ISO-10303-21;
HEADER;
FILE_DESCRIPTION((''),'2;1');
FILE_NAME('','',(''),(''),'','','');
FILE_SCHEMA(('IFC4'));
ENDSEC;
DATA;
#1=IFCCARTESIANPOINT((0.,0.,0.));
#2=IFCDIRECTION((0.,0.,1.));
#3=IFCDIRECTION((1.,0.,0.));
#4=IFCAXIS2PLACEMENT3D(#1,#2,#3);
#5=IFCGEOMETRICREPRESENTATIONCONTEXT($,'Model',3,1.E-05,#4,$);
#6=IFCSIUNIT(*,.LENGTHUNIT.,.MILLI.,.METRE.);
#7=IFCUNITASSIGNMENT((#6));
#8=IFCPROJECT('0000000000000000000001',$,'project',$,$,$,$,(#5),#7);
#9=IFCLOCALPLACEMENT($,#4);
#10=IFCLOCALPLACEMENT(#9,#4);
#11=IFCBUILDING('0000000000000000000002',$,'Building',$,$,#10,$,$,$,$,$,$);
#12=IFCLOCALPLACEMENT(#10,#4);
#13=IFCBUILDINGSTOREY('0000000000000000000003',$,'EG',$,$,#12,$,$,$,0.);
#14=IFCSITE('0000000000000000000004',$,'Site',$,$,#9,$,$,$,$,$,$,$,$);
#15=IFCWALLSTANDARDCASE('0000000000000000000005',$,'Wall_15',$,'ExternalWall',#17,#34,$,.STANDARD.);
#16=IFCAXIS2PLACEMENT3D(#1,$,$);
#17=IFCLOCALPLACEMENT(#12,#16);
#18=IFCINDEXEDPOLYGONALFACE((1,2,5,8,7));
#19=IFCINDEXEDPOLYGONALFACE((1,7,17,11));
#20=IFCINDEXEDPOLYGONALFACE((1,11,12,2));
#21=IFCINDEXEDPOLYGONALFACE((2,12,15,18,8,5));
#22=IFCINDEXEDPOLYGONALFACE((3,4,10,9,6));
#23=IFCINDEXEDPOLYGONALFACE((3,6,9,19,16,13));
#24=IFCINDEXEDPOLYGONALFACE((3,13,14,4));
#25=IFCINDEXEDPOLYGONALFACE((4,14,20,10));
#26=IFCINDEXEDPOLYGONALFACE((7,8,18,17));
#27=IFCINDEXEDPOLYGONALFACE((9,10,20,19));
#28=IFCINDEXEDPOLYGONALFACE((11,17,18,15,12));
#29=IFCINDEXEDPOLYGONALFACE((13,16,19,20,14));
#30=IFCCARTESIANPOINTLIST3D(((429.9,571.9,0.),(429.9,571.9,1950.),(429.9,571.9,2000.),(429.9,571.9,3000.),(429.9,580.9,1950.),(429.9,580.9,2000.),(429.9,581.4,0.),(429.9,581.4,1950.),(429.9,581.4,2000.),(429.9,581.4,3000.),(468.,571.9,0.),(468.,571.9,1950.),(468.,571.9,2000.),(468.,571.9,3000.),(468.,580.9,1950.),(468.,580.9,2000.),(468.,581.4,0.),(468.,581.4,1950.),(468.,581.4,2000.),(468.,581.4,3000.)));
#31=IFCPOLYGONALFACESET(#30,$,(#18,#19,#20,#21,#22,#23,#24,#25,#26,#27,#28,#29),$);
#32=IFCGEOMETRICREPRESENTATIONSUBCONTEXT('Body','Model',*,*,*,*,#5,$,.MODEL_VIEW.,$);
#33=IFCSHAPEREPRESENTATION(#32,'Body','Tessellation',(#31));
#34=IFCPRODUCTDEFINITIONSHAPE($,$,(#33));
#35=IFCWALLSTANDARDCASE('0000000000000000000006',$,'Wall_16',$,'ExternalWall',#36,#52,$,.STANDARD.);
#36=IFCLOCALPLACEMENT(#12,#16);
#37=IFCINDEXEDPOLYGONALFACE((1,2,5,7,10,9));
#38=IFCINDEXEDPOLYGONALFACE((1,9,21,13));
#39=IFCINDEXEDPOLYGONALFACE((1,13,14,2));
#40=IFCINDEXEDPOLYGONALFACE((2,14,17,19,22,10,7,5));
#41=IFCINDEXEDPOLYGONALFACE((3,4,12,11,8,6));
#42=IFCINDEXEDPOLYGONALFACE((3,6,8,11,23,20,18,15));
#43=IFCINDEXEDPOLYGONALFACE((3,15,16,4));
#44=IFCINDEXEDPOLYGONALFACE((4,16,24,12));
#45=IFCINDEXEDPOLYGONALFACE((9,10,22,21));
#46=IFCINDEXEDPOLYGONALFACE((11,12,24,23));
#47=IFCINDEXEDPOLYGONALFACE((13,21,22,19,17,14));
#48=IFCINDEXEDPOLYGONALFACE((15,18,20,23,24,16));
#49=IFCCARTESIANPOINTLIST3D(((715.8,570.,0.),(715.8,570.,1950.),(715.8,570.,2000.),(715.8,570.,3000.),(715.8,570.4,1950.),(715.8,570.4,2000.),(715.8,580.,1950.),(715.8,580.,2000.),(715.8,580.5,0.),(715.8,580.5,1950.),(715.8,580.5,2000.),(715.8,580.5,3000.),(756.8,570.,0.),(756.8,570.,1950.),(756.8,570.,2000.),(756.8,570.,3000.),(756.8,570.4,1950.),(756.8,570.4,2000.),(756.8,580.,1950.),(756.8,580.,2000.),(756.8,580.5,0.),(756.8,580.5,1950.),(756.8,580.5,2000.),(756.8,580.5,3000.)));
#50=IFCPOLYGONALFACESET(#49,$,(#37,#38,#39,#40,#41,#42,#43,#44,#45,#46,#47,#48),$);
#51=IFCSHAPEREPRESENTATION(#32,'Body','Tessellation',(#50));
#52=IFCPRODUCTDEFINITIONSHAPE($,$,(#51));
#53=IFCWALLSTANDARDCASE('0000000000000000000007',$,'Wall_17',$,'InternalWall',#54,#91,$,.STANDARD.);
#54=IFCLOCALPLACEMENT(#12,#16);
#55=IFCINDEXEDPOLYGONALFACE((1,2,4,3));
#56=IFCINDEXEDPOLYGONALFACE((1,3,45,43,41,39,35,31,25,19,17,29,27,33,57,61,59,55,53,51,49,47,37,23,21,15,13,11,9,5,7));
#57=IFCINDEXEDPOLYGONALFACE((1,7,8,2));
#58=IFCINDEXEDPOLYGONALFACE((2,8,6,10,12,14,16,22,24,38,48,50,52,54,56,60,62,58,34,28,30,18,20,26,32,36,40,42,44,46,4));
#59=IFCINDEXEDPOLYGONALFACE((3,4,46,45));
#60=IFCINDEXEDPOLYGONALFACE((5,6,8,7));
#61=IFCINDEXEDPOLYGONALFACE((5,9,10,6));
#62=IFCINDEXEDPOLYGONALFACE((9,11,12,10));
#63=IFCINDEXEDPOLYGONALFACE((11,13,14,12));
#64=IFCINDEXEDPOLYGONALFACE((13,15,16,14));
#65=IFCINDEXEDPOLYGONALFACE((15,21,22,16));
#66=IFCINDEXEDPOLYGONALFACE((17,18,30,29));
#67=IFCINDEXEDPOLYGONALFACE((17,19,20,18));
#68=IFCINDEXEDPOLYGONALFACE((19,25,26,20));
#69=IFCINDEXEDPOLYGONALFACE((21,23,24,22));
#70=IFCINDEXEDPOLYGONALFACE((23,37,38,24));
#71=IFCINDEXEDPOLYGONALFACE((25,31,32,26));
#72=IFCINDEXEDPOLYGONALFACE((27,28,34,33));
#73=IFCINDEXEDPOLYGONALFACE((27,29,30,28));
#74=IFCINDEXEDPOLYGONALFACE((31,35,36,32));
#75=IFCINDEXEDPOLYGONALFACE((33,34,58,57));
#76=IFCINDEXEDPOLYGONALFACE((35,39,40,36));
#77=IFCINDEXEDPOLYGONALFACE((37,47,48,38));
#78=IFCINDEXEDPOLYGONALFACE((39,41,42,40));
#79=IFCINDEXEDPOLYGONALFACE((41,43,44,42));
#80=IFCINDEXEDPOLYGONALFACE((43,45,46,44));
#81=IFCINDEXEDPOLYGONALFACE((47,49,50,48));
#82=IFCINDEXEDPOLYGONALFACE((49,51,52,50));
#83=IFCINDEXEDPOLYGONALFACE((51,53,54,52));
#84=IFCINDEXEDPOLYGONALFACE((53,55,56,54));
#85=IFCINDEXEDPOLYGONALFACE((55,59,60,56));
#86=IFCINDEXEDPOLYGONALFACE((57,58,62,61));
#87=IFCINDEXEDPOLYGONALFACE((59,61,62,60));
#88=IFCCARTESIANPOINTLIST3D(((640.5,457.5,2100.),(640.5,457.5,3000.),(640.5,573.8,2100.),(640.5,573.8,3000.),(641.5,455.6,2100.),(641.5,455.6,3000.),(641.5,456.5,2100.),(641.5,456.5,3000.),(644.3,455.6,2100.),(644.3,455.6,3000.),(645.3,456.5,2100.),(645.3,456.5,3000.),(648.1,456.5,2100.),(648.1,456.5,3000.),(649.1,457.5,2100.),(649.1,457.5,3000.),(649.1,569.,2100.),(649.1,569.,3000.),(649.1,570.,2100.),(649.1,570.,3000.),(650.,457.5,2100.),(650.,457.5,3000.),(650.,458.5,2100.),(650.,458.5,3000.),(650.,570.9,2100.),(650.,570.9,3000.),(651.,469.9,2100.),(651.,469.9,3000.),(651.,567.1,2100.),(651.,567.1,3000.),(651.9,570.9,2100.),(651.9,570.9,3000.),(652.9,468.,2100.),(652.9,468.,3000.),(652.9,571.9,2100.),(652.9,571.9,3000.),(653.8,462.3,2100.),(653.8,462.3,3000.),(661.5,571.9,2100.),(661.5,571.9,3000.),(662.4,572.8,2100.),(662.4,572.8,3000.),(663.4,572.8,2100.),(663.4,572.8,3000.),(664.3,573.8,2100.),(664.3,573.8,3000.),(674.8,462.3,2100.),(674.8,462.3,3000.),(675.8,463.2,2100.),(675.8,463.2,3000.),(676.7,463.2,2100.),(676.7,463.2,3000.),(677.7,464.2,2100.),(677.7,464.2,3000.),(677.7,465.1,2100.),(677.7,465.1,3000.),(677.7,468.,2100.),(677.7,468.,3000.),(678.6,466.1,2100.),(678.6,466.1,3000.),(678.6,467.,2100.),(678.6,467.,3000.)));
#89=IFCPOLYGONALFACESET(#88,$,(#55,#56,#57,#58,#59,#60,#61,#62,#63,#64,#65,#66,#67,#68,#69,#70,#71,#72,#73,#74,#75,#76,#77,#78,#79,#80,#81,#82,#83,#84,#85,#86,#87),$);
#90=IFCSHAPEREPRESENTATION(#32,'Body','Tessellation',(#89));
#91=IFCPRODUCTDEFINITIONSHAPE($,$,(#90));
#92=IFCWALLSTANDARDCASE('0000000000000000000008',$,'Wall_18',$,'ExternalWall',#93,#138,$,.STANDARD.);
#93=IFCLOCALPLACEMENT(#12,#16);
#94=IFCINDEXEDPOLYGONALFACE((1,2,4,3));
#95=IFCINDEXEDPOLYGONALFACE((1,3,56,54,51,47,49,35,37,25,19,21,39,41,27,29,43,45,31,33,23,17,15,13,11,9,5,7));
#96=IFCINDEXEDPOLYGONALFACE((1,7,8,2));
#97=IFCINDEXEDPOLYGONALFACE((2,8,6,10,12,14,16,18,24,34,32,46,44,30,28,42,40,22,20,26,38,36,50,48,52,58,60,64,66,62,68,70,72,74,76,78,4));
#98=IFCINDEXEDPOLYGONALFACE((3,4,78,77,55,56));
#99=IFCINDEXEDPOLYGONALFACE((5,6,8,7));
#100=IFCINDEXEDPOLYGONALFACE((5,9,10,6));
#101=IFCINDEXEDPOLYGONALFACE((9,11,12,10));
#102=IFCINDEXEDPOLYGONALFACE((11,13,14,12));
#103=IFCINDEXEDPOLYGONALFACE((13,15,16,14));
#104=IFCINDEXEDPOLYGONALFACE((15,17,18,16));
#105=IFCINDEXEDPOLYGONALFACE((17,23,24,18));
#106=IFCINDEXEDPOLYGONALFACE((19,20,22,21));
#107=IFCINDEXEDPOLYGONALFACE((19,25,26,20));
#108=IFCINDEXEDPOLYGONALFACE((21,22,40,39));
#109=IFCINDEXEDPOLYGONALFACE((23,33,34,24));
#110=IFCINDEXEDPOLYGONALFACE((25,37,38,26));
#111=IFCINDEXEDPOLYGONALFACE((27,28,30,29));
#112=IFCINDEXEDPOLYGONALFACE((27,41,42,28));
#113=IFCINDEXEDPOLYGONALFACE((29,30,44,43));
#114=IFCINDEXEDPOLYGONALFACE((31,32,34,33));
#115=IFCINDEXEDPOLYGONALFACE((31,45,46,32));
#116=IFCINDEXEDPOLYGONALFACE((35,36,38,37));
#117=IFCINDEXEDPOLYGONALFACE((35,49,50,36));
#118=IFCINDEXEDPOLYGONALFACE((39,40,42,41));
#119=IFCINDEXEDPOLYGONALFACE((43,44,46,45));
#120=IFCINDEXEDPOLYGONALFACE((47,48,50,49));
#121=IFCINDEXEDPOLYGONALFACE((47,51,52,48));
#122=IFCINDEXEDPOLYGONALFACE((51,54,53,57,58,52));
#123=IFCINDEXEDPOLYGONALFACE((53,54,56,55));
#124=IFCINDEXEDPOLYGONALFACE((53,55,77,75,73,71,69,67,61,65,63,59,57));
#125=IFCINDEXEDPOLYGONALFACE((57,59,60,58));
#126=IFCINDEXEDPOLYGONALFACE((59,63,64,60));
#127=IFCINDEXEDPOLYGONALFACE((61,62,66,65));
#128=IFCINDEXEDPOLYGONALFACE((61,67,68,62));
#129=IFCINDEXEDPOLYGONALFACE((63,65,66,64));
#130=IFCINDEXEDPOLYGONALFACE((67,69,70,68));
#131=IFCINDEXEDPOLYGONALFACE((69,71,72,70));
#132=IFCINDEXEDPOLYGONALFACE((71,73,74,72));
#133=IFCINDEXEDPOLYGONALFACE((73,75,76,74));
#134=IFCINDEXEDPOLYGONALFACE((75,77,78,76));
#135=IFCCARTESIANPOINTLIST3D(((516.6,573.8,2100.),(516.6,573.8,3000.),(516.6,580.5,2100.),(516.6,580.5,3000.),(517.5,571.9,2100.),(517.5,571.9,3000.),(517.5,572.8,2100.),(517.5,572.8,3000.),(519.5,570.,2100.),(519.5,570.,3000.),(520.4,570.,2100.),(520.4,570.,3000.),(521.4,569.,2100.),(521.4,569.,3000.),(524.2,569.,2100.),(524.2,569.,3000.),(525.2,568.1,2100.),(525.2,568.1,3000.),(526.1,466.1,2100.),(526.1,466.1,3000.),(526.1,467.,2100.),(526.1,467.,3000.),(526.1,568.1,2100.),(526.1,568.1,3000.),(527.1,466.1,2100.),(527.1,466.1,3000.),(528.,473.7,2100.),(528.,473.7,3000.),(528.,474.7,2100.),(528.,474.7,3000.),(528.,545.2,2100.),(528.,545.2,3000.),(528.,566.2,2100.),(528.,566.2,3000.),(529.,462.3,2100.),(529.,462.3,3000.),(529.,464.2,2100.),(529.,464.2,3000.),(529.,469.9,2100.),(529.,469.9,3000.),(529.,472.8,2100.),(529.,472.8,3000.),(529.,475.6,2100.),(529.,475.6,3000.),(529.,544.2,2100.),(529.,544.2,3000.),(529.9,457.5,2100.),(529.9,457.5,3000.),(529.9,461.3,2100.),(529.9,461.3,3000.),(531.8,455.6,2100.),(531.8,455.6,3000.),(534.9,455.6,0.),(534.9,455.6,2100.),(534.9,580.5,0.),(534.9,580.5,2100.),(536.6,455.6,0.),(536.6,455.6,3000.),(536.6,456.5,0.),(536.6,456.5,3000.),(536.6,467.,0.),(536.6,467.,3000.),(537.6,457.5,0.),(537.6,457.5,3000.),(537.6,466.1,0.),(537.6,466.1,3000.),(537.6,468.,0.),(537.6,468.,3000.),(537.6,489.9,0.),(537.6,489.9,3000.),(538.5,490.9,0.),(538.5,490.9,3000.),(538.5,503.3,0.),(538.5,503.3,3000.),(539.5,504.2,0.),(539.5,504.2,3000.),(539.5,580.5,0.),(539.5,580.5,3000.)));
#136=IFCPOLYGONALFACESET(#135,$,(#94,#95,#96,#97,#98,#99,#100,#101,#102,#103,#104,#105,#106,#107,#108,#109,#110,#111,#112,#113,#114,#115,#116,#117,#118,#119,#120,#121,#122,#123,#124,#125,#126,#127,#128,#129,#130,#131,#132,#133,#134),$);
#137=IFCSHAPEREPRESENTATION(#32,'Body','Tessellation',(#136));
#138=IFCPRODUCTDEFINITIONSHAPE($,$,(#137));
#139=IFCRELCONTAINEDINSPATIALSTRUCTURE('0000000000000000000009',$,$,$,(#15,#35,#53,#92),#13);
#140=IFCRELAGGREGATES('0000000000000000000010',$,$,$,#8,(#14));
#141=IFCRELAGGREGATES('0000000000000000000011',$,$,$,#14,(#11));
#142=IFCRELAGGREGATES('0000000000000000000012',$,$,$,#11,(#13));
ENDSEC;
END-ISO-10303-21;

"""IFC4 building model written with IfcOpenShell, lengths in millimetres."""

from ifc_helpers import new_model, si_unit, frame, origin_with_axes, place, context, subcontext, project, spatial, polyline, rectangle, outline, extrude, element, save


model = new_model("IFC4")

# Units and contexts
model_context = context("Model", 3, precision=1e-05, world=origin_with_axes())
body_context = subcontext(model_context, "Body", "Model", "MODEL_VIEW")
ifc_project = project(units=[si_unit("LENGTHUNIT", "METRE", prefix="MILLI")], contexts=[model_context])

# Site, building, storey
site_placement = place(None, origin_with_axes())
site = spatial("IfcSite", under=ifc_project, at=site_placement, Name="Site")
building_placement = place(site_placement, origin_with_axes())
building = spatial("IfcBuilding", under=site, at=building_placement, Name="Building")
storey_placement = place(building_placement, origin_with_axes())
storey = spatial("IfcBuildingStorey", under=building, at=storey_placement, Name="EG", Elevation=0.0)

# Walls, openings
wall_1_placement = place(storey_placement, origin_with_axes())
wall_1 = element("IfcWallStandardCase", 1, at=wall_1_placement, inside=storey, Name="Wall_15", ObjectType="ExternalWall", PredefinedType="STANDARD", context=body_context, shape_type="SweptSolid", body=[
    extrude(outline(polyline([(429.9, 571.9, 0.0), (429.9, 581.4, 0.0), (468.0, 581.4, 0.0), (468.0, 571.9, 0.0), (429.9, 571.9, 0.0)])), origin_with_axes(), (0.0, 0.0, 1.0), 3000.0),
])
opening_1_placement = place(wall_1_placement, origin_with_axes())
element("IfcOpeningElement", 2, at=opening_1_placement, inside=storey, cuts=wall_1, context=body_context, shape_type="SweptSolid", body=[
    extrude(rectangle(XDim=1200.0, YDim=9.5), frame((403.0, 576.1, 1950.0), z_axis=(0.0, 0.0, 1.0), x_axis=(1.0, 0.0, 0.0)), (0.0, 0.0, 1.0), 50.0),
])
opening_2_placement = place(wall_1_placement, origin_with_axes())
element("IfcOpeningElement", 3, at=opening_2_placement, inside=storey, cuts=wall_1, context=body_context, shape_type="SweptSolid", body=[
    extrude(rectangle(XDim=1200.0, YDim=9.5), frame((492.2, 576.6, 1950.0), z_axis=(0.0, 0.0, 1.0), x_axis=(1.0, 0.0, 0.0)), (0.0, 0.0, 1.0), 50.0),
])
wall_2_placement = place(storey_placement, origin_with_axes())
wall_2 = element("IfcWallStandardCase", 4, at=wall_2_placement, inside=storey, Name="Wall_16", ObjectType="ExternalWall", PredefinedType="STANDARD", context=body_context, shape_type="SweptSolid", body=[
    extrude(outline(polyline([(715.8, 570.0, 0.0), (715.8, 580.5, 0.0), (756.8, 580.5, 0.0), (756.8, 570.0, 0.0), (715.8, 570.0, 0.0)])), origin_with_axes(), (0.0, 0.0, 1.0), 3000.0),
])
opening_3_placement = place(wall_2_placement, origin_with_axes())
element("IfcOpeningElement", 5, at=opening_3_placement, inside=storey, cuts=wall_2, context=body_context, shape_type="SweptSolid", body=[
    extrude(rectangle(XDim=1200.0, YDim=10.5), frame((805.3, 574.7, 1950.0), z_axis=(0.0, 0.0, 1.0), x_axis=(1.0, 0.0, 0.0)), (0.0, 0.0, 1.0), 50.0),
])
opening_4_placement = place(wall_2_placement, origin_with_axes())
element("IfcOpeningElement", 6, at=opening_4_placement, inside=storey, cuts=wall_2, context=body_context, shape_type="SweptSolid", body=[
    extrude(rectangle(XDim=1200.0, YDim=10.5), frame((691.7, 575.6, 1950.0), z_axis=(0.0, 0.0, 1.0), x_axis=(1.0, 0.0, 0.0)), (0.0, 0.0, 1.0), 50.0),
])
wall_3_placement = place(storey_placement, origin_with_axes())
wall_3 = element("IfcWallStandardCase", 7, at=wall_3_placement, inside=storey, Name="Wall_17", ObjectType="InternalWall", PredefinedType="STANDARD", context=body_context, shape_type="SweptSolid", body=[
    extrude(outline(polyline([(641.5, 455.6, 0.0), (641.5, 456.5, 0.0), (640.5, 457.5, 0.0), (640.5, 573.8, 0.0), (664.3, 573.8, 0.0), (663.4, 572.8, 0.0), (662.4, 572.8, 0.0), (661.5, 571.9, 0.0), (652.9, 571.9, 0.0), (651.9, 570.9, 0.0), (650.0, 570.9, 0.0), (649.1, 570.0, 0.0), (649.1, 569.0, 0.0), (651.0, 567.1, 0.0), (651.0, 469.9, 0.0), (652.9, 468.0, 0.0), (677.7, 468.0, 0.0), (678.6, 467.0, 0.0), (678.6, 466.1, 0.0), (677.7, 465.1, 0.0), (677.7, 464.2, 0.0), (676.7, 463.2, 0.0), (675.8, 463.2, 0.0), (674.8, 462.3, 0.0), (653.8, 462.3, 0.0), (650.0, 458.5, 0.0), (650.0, 457.5, 0.0), (649.1, 457.5, 0.0), (648.1, 456.5, 0.0), (645.3, 456.5, 0.0), (644.3, 455.6, 0.0), (641.5, 455.6, 0.0)])), origin_with_axes(), (0.0, 0.0, 1.0), 3000.0),
])
opening_5_placement = place(wall_3_placement, origin_with_axes())
element("IfcOpeningElement", 8, at=opening_5_placement, inside=storey, cuts=wall_3, context=body_context, shape_type="SweptSolid", body=[
    extrude(rectangle(XDim=450.0, YDim=38.1), frame((659.6, 456.1, 0.0), z_axis=(0.0, 0.0, 1.0), x_axis=(0.0, 1.0, 0.0)), (0.0, 0.0, 1.0), 2100.0),
])
opening_6_placement = place(wall_3_placement, origin_with_axes())
element("IfcOpeningElement", 9, at=opening_6_placement, inside=storey, cuts=wall_3, context=body_context, shape_type="SweptSolid", body=[
    extrude(rectangle(XDim=600.0, YDim=38.1), frame((659.6, 572.8, 1950.0), z_axis=(0.0, 0.0, 1.0), x_axis=(0.0, 1.0, 0.0)), (0.0, 0.0, 1.0), 50.0),
])
opening_7_placement = place(wall_3_placement, origin_with_axes())
element("IfcOpeningElement", 10, at=opening_7_placement, inside=storey, cuts=wall_3, context=body_context, shape_type="SweptSolid", body=[
    extrude(rectangle(XDim=600.0, YDim=38.1), frame((659.6, 539.9, 1950.0), z_axis=(0.0, 0.0, 1.0), x_axis=(0.0, 1.0, 0.0)), (0.0, 0.0, 1.0), 50.0),
])

# Wall, opening
wall_4_placement = place(storey_placement, origin_with_axes())
wall_4 = element("IfcWallStandardCase", 11, at=wall_4_placement, inside=storey, Name="Wall_18", ObjectType="ExternalWall", PredefinedType="STANDARD", context=body_context, shape_type="SweptSolid", body=[
    extrude(outline(polyline([(531.8, 455.6, 0.0), (529.9, 457.5, 0.0), (529.9, 461.3, 0.0), (529.0, 462.3, 0.0), (529.0, 464.2, 0.0), (527.1, 466.1, 0.0), (526.1, 466.1, 0.0), (526.1, 467.0, 0.0), (529.0, 469.9, 0.0), (529.0, 472.8, 0.0), (528.0, 473.7, 0.0), (528.0, 474.7, 0.0), (529.0, 475.6, 0.0), (529.0, 544.2, 0.0), (528.0, 545.2, 0.0), (528.0, 566.2, 0.0), (526.1, 568.1, 0.0), (525.2, 568.1, 0.0), (524.2, 569.0, 0.0), (521.4, 569.0, 0.0), (520.4, 570.0, 0.0), (519.5, 570.0, 0.0), (517.5, 571.9, 0.0), (517.5, 572.8, 0.0), (516.6, 573.8, 0.0), (516.6, 580.5, 0.0), (539.5, 580.5, 0.0), (539.5, 504.2, 0.0), (538.5, 503.3, 0.0), (538.5, 490.9, 0.0), (537.6, 489.9, 0.0), (537.6, 468.0, 0.0), (536.6, 467.0, 0.0), (537.6, 466.1, 0.0), (537.6, 457.5, 0.0), (536.6, 456.5, 0.0), (536.6, 455.6, 0.0), (531.8, 455.6, 0.0)])), origin_with_axes(), (0.0, 0.0, 1.0), 3000.0),
])
opening_8_placement = place(wall_4_placement, origin_with_axes())
element("IfcOpeningElement", 12, at=opening_8_placement, inside=storey, cuts=wall_4, context=body_context, shape_type="SweptSolid", body=[
    extrude(rectangle(XDim=900.0, YDim=22.9), frame((523.4, 438.6, 0.0), z_axis=(0.0, 0.0, 1.0), x_axis=(0.0, 1.0, 0.0)), (0.0, 0.0, 1.0), 2100.0),
])

save(model, "model.ifc")
